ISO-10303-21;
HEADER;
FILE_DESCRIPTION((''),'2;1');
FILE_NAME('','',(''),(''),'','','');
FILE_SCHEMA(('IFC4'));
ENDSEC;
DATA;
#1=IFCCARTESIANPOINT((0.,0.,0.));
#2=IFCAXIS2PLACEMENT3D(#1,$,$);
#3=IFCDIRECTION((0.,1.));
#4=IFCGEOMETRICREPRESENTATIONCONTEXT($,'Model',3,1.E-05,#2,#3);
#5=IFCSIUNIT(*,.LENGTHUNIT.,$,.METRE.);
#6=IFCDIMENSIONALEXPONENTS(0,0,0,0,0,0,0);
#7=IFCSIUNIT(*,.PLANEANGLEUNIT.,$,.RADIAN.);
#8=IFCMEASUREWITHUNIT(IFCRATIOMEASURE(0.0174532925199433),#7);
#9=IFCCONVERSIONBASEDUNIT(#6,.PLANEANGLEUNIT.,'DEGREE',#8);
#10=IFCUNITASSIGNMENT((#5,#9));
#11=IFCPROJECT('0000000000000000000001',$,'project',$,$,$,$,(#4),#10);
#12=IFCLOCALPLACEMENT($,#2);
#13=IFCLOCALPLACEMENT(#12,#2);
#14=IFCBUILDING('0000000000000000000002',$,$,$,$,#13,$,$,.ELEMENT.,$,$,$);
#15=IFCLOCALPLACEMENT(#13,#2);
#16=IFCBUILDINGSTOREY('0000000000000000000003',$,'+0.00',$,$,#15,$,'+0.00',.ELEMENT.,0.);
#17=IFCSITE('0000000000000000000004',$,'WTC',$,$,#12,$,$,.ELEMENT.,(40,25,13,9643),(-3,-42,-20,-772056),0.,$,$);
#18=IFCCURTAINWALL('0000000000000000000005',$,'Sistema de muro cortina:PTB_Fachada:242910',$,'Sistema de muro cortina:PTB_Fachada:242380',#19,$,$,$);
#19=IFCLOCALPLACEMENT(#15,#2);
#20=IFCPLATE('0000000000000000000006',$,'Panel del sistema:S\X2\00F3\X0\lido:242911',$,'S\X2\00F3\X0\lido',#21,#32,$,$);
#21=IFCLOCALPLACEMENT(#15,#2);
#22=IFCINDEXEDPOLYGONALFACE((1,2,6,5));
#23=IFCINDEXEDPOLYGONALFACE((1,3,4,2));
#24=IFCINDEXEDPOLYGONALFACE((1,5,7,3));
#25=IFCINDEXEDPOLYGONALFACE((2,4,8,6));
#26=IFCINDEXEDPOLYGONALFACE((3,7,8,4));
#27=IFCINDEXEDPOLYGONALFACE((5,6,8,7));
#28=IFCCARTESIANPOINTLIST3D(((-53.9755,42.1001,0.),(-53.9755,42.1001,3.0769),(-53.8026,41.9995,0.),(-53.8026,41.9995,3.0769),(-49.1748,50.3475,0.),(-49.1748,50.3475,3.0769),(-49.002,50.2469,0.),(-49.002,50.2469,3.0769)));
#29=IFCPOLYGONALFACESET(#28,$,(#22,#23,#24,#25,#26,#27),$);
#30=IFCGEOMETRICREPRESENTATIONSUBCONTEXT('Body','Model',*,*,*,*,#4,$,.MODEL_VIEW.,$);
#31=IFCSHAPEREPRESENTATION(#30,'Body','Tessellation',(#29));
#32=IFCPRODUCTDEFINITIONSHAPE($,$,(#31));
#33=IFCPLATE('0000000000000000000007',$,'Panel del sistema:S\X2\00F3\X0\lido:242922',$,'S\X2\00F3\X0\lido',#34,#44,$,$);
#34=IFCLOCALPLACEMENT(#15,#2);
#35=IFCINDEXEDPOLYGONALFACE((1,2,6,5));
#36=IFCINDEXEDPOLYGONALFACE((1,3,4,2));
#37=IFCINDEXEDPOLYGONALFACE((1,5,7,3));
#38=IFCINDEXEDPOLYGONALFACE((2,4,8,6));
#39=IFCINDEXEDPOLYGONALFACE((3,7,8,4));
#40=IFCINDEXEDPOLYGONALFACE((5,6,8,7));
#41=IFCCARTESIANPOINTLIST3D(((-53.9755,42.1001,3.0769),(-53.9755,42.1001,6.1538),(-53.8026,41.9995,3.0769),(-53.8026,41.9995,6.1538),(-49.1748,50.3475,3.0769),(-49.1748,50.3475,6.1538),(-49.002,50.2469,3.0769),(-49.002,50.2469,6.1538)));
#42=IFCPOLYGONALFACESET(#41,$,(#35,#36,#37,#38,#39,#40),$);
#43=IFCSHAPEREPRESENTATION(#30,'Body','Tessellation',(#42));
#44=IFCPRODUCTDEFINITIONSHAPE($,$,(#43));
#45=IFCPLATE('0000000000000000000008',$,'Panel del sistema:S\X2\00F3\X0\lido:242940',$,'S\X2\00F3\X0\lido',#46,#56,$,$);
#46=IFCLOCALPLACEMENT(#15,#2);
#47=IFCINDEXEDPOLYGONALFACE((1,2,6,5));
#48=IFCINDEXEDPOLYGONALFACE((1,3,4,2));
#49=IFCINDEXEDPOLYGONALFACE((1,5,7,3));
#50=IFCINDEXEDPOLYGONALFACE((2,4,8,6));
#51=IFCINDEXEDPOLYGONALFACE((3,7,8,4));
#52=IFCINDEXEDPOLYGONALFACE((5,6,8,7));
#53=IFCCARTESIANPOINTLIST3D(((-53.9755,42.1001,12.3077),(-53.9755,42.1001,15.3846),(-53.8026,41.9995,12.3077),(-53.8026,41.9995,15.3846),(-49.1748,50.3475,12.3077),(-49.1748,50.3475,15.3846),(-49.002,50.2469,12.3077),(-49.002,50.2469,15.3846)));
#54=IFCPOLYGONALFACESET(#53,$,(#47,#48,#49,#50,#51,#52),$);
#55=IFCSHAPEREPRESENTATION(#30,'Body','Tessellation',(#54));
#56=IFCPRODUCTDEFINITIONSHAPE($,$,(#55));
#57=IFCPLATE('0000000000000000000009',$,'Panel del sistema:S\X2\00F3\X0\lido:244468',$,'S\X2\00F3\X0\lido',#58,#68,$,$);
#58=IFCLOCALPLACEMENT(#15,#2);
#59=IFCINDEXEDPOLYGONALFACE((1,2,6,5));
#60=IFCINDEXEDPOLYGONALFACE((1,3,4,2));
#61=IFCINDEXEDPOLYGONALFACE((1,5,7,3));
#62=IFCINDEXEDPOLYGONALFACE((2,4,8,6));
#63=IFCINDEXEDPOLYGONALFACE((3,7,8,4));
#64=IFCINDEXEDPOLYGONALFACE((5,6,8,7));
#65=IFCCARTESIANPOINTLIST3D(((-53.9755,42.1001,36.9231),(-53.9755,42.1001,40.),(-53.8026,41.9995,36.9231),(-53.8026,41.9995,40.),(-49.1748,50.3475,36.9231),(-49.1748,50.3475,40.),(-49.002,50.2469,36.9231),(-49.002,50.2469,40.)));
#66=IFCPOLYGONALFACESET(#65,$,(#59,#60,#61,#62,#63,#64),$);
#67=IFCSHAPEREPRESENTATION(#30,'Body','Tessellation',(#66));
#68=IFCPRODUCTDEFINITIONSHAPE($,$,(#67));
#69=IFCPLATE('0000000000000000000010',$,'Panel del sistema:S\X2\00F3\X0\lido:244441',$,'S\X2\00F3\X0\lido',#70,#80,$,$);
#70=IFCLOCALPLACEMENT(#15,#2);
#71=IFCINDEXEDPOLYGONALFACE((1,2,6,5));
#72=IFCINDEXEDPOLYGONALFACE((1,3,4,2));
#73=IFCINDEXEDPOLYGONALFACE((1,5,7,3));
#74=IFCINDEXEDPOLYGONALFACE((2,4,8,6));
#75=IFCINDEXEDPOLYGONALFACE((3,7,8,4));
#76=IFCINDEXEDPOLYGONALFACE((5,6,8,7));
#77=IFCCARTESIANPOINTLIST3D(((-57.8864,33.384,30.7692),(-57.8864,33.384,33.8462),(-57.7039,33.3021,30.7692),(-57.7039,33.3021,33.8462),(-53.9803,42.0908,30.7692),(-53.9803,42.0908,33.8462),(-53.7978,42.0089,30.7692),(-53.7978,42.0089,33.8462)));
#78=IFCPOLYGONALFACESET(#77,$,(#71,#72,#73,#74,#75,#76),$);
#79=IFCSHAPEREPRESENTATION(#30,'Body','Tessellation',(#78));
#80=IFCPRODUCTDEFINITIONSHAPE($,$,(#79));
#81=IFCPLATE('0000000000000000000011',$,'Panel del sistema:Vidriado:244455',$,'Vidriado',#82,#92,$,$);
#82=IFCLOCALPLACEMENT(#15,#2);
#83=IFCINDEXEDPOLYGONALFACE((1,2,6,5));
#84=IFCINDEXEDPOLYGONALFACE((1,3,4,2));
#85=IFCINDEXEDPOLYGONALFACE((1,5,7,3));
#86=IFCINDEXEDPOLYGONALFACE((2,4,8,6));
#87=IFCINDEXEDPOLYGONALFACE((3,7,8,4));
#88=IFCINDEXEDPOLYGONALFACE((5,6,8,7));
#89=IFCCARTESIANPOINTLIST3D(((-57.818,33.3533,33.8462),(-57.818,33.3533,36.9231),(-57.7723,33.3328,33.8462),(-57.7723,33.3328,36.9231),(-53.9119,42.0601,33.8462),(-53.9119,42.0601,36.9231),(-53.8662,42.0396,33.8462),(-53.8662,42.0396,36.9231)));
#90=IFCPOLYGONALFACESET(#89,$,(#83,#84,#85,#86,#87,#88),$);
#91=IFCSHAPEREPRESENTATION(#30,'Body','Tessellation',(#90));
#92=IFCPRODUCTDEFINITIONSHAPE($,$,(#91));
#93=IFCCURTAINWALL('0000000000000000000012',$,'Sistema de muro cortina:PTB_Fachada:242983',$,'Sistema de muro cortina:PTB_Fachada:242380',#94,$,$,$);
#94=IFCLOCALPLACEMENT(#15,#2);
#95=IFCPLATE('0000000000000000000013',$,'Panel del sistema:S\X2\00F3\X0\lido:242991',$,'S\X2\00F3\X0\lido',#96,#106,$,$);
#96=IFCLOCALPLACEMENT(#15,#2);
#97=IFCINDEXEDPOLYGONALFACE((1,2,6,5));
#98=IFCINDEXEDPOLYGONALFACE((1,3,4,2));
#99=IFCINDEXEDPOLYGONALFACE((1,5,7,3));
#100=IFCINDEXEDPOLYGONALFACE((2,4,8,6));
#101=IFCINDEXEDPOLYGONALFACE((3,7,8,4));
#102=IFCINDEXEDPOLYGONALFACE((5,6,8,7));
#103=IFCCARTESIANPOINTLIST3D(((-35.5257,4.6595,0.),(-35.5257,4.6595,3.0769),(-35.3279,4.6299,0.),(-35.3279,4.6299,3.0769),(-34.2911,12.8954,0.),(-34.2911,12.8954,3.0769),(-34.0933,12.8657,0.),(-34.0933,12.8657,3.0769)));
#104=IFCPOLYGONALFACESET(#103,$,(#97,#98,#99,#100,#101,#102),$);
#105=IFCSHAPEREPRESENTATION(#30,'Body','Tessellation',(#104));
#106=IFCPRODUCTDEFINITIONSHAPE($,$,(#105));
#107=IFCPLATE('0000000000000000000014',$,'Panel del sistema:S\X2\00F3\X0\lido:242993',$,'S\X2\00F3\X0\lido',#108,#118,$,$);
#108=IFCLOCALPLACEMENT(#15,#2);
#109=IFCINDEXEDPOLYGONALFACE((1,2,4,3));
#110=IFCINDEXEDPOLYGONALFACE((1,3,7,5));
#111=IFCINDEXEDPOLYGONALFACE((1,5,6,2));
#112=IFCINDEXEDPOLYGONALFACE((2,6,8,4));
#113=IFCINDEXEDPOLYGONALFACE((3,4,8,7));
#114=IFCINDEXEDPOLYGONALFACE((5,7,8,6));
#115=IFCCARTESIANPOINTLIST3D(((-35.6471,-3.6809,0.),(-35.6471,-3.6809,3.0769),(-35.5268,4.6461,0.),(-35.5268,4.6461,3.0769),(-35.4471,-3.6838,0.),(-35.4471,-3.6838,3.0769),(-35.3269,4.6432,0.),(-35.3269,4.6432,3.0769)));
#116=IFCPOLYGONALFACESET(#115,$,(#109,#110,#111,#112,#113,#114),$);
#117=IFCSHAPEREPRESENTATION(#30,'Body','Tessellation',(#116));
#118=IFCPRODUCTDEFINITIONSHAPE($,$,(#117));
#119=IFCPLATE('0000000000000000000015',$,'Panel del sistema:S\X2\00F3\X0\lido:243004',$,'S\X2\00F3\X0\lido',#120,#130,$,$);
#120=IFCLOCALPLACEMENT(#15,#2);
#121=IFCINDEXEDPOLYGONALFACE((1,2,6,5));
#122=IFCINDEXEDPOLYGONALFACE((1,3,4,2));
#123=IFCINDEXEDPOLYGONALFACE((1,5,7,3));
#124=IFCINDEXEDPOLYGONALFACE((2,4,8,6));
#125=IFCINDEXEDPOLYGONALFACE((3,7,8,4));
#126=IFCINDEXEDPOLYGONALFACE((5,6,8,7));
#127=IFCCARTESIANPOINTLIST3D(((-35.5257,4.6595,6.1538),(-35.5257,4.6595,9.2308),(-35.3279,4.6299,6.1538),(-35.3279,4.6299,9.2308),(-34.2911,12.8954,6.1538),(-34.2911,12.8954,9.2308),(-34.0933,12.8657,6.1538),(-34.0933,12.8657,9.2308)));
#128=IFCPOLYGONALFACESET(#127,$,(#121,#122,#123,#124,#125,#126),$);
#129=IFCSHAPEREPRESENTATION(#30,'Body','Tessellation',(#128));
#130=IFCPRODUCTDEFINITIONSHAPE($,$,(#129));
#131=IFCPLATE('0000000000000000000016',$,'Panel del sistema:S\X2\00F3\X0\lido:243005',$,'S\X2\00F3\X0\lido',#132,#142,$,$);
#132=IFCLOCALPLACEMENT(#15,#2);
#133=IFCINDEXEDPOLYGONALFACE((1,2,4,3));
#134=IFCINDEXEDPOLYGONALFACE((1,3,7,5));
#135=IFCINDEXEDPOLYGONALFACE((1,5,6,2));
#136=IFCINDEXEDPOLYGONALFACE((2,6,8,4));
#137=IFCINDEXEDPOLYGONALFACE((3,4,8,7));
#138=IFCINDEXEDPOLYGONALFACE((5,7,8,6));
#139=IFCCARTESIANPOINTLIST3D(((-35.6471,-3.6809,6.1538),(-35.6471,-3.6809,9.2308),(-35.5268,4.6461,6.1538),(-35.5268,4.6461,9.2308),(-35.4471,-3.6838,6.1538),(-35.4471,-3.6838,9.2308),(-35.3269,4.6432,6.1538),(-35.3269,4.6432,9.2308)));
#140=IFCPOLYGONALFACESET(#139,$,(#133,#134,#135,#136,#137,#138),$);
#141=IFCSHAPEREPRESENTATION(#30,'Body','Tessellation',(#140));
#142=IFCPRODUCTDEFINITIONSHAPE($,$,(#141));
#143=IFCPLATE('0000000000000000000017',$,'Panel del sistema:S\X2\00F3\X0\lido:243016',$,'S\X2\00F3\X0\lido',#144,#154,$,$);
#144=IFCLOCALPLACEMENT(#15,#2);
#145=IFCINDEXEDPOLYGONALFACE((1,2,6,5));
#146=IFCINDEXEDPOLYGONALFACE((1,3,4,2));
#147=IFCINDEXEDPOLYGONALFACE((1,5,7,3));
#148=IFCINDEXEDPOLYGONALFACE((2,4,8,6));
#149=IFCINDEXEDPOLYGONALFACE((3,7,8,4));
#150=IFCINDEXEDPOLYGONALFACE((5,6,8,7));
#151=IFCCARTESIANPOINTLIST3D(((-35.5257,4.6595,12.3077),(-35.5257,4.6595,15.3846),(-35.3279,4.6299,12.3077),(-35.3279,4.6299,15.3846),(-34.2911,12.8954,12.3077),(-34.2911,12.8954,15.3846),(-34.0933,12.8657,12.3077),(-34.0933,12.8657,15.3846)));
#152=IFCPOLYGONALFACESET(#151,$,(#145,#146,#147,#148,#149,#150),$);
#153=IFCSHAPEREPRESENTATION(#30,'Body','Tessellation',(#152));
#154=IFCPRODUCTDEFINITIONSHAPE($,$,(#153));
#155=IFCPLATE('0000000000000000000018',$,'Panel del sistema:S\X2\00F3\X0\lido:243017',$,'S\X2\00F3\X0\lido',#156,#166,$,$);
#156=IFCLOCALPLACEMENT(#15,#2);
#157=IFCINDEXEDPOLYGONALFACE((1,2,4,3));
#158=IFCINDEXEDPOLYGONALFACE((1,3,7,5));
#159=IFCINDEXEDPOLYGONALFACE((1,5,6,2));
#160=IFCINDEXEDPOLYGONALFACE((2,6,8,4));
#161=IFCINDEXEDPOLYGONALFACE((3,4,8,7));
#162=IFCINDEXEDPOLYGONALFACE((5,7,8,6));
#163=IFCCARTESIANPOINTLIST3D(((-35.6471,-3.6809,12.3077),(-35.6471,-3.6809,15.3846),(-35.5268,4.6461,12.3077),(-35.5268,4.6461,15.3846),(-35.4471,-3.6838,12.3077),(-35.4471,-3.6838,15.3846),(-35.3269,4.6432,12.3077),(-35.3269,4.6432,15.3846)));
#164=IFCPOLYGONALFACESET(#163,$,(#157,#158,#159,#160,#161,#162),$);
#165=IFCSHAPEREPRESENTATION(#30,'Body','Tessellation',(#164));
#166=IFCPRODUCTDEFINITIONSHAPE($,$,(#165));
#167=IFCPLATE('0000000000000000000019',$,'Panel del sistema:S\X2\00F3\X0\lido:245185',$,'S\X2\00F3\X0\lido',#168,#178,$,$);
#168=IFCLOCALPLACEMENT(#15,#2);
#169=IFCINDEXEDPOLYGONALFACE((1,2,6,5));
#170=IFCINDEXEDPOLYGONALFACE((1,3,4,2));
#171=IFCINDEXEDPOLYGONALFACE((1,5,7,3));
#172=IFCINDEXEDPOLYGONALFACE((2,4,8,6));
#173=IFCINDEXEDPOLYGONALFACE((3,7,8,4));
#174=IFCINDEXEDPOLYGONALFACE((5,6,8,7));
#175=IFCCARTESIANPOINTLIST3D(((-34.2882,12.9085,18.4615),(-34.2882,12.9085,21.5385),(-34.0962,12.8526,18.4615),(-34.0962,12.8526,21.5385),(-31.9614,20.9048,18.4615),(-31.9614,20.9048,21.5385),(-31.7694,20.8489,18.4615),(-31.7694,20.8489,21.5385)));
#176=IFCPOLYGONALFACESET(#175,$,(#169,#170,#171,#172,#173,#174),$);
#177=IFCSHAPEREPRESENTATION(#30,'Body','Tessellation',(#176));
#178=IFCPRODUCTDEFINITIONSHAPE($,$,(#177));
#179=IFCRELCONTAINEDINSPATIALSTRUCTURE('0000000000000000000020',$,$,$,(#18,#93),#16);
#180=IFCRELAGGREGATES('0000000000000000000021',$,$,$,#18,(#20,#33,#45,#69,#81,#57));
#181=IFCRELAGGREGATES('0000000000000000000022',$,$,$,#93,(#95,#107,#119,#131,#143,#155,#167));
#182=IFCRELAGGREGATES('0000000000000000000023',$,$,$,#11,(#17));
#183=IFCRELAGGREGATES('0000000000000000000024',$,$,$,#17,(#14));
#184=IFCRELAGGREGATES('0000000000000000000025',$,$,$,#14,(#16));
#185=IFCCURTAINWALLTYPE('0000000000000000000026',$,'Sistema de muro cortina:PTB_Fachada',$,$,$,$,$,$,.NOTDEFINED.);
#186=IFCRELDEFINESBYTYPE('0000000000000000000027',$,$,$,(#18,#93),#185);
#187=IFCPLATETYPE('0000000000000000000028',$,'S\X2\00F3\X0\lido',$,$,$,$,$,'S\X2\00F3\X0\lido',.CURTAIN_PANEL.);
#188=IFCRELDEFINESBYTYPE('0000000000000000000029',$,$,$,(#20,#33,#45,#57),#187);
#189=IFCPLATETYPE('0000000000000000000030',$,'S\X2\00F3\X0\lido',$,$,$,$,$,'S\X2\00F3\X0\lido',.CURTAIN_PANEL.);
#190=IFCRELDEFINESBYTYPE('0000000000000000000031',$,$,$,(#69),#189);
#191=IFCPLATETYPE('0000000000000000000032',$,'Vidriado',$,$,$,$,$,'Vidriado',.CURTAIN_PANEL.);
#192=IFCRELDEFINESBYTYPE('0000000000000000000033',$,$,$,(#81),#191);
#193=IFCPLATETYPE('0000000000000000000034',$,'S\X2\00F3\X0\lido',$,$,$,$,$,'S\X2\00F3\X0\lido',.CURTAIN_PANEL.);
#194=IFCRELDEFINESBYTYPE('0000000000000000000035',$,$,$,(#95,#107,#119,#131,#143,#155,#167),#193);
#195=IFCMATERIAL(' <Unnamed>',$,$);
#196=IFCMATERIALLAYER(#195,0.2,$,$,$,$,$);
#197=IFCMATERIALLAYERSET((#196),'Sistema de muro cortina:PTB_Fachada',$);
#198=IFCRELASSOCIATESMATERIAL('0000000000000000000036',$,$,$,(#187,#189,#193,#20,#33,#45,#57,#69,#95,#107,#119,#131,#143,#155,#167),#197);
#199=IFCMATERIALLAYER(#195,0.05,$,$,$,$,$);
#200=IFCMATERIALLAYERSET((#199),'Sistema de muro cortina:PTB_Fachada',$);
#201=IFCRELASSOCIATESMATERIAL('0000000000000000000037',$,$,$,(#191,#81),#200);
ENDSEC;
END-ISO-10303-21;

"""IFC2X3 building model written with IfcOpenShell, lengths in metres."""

from ifc_helpers import new_model, entity, si_unit, converted_unit, direction, frame, frame_2d, origin, origin_2d_with_axis, place, context, subcontext, project, spatial, rectangle, extrude, source, transform, mapped, material, layer, layer_set, layer_usage, type_object, type_shapes, element, aggregate, save


model = new_model("IFC2X3")

# Units and contexts
model_context = context("Model", 3, precision=1e-05, world=origin(), true_north=direction((0.0, 1.0)))
body_context = subcontext(model_context, "Body", "Model", "MODEL_VIEW")
ifc_project = project(units=[si_unit("LENGTHUNIT", "METRE"), converted_unit("PLANEANGLEUNIT", "DEGREE", entity("IfcRatioMeasure", 0.0174532925199433), si_unit("PLANEANGLEUNIT", "RADIAN"), dimensions=[0, 0, 0, 0, 0, 0, 0])], contexts=[model_context])

# Site, building, storey
site_placement = place(None, origin())
site = spatial("IfcSite", under=ifc_project, at=site_placement, Name="WTC", CompositionType="ELEMENT", RefLatitude=(40, 25, 13, 9643), RefLongitude=(-3, -42, -20, -772056), RefElevation=0.0)
building_placement = place(site_placement, origin())
building = spatial("IfcBuilding", under=site, at=building_placement, CompositionType="ELEMENT")
storey_placement = place(building_placement, origin())
storey = spatial("IfcBuildingStorey", under=building, at=storey_placement, Name="+0.00", LongName="+0.00", CompositionType="ELEMENT", Elevation=0.0)

# Curtain walls, plates
curtain_wall_type = type_object("IfcCurtainWallType", Name="Sistema de muro cortina:PTB_Fachada", PredefinedType="NOTDEFINED")
curtain_wall_1_placement = place(storey_placement, origin())
curtain_wall_1 = element("IfcCurtainWall", 1, at=curtain_wall_1_placement, inside=storey, type_object=curtain_wall_type, Name="Sistema de muro cortina:PTB_Fachada:242910", ObjectType="Sistema de muro cortina:PTB_Fachada:242380")
ifc_material_1 = material(Name=" <Unnamed>")
ifc_layer_1 = layer(ifc_material_1, 0.2)
ifc_layer_set_1 = layer_set([ifc_layer_1], Name="Sistema de muro cortina:PTB_Fachada")
ifc_layer_usage_1 = layer_usage(ifc_layer_set_1, "AXIS3", "POSITIVE", 0.0)
plate_type_1 = type_object("IfcPlateType", Name="Sólido", ElementType="Sólido", PredefinedType="CURTAIN_PANEL", material=ifc_layer_set_1)
shared_shape_1 = source(origin(), body_context, "Body", "SweptSolid", [
    extrude(rectangle(XDim=0.2, YDim=9.5428, at=frame_2d((0.0, 0.0), x_axis=(1.0, 0.0))), frame((0.0, 0.0, 0.0), z_axis=(0.0, 0.0, 1.0), x_axis=(0.0, 1.0, 0.0)), (0.0, 0.0, 1.0), 3.0769),
])
type_shapes(plate_type_1, [shared_shape_1])
plate_1_placement = place(curtain_wall_1_placement, frame((-51.4887, 46.1735, 0.0), z_axis=(0.0, 0.0, 1.0), x_axis=(-0.503062, -0.864251, 0.0)))
plate_1 = element("IfcPlate", 2, at=plate_1_placement, type_object=plate_type_1, material=ifc_layer_usage_1, Name="Panel del sistema:Sólido:242911", ObjectType="Sólido", context=body_context, shape_type="MappedRepresentation", body=[
    mapped(shared_shape_1, transform((0.0, 0.0, 0.0), scale=1.0)),
])
ifc_layer_usage_2 = layer_usage(ifc_layer_set_1, "AXIS3", "POSITIVE", 0.0)
plate_2_placement = place(curtain_wall_1_placement, frame((-51.4887, 46.1735, 3.0769), z_axis=(0.0, 0.0, 1.0), x_axis=(-0.503062, -0.864251, 0.0)))
plate_2 = element("IfcPlate", 3, at=plate_2_placement, type_object=plate_type_1, material=ifc_layer_usage_2, Name="Panel del sistema:Sólido:242922", ObjectType="Sólido", context=body_context, shape_type="MappedRepresentation", body=[
    mapped(shared_shape_1, transform((0.0, 0.0, 0.0), scale=1.0)),
])
ifc_layer_usage_3 = layer_usage(ifc_layer_set_1, "AXIS3", "POSITIVE", 0.0)
plate_3_placement = place(curtain_wall_1_placement, frame((-51.4887, 46.1735, 12.3077), z_axis=(0.0, 0.0, 1.0), x_axis=(-0.503062, -0.864251, 0.0)))
plate_3 = element("IfcPlate", 4, at=plate_3_placement, type_object=plate_type_1, material=ifc_layer_usage_3, Name="Panel del sistema:Sólido:242940", ObjectType="Sólido", context=body_context, shape_type="MappedRepresentation", body=[
    mapped(shared_shape_1, transform((0.0, 0.0, 0.0), scale=1.0)),
])
ifc_layer_usage_4 = layer_usage(ifc_layer_set_1, "AXIS3", "POSITIVE", 0.0)
plate_4_placement = place(curtain_wall_1_placement, frame((-51.4887, 46.1735, 36.9231), z_axis=(0.0, 0.0, 1.0), x_axis=(-0.503062, -0.864251, 0.0)))
plate_4 = element("IfcPlate", 5, at=plate_4_placement, type_object=plate_type_1, material=ifc_layer_usage_4, Name="Panel del sistema:Sólido:244468", ObjectType="Sólido", context=body_context, shape_type="MappedRepresentation", body=[
    mapped(shared_shape_1, transform((0.0, 0.0, 0.0), scale=1.0)),
])
ifc_layer_usage_5 = layer_usage(ifc_layer_set_1, "AXIS3", "POSITIVE", 0.0)
plate_type_2 = type_object("IfcPlateType", Name="Sólido", ElementType="Sólido", PredefinedType="CURTAIN_PANEL", material=ifc_layer_set_1)
shared_shape_2 = source(origin(), body_context, "Body", "SweptSolid", [
    extrude(rectangle(XDim=0.2, YDim=9.5428, at=frame_2d((0.0, 0.0), x_axis=(1.0, 0.0))), frame((0.0, 0.0, 0.0), z_axis=(0.0, 0.0, 1.0), x_axis=(0.0, 1.0, 0.0)), (0.0, 0.0, 1.0), 3.0769),
])
type_shapes(plate_type_2, [shared_shape_2])
plate_5_placement = place(curtain_wall_1_placement, frame((-55.8421, 37.6964, 30.7692), z_axis=(0.0, 0.0, 1.0), x_axis=(-0.409321, -0.91239, 0.0)))
plate_5 = element("IfcPlate", 6, at=plate_5_placement, type_object=plate_type_2, material=ifc_layer_usage_5, Name="Panel del sistema:Sólido:244441", ObjectType="Sólido", context=body_context, shape_type="MappedRepresentation", body=[
    mapped(shared_shape_2, transform((0.0, 0.0, 0.0), scale=1.0)),
])
ifc_layer_2 = layer(ifc_material_1, 0.05)
ifc_layer_set_2 = layer_set([ifc_layer_2], Name="Sistema de muro cortina:PTB_Fachada")
ifc_layer_usage_6 = layer_usage(ifc_layer_set_2, "AXIS3", "POSITIVE", 0.0)
plate_type_3 = type_object("IfcPlateType", Name="Vidriado", ElementType="Vidriado", PredefinedType="CURTAIN_PANEL", material=ifc_layer_set_2)
shared_shape_3 = source(origin(), body_context, "Body", "SweptSolid", [
    extrude(rectangle(XDim=0.05, YDim=9.5428, at=origin_2d_with_axis()), frame((0.0, 0.0, 0.0), z_axis=(0.0, 0.0, 1.0), x_axis=(0.0, 1.0, 0.0)), (0.0, 0.0, 1.0), 3.0769),
])
type_shapes(plate_type_3, [shared_shape_3])
plate_6_placement = place(curtain_wall_1_placement, frame((-55.8421, 37.6964, 33.8462), z_axis=(0.0, 0.0, 1.0), x_axis=(-0.409321, -0.91239, 0.0)))
plate_6 = element("IfcPlate", 7, at=plate_6_placement, type_object=plate_type_3, material=ifc_layer_usage_6, Name="Panel del sistema:Vidriado:244455", ObjectType="Vidriado", context=body_context, shape_type="MappedRepresentation", body=[
    mapped(shared_shape_3, transform((0.0, 0.0, 0.0), scale=1.0)),
])
aggregate(curtain_wall_1, [plate_1, plate_2, plate_3, plate_5, plate_6, plate_4])
curtain_wall_2_placement = place(storey_placement, origin())
curtain_wall_2 = element("IfcCurtainWall", 8, at=curtain_wall_2_placement, inside=storey, type_object=curtain_wall_type, Name="Sistema de muro cortina:PTB_Fachada:242983", ObjectType="Sistema de muro cortina:PTB_Fachada:242380")
ifc_layer_usage_7 = layer_usage(ifc_layer_set_1, "AXIS3", "POSITIVE", 0.0)
plate_type_4 = type_object("IfcPlateType", Name="Sólido", ElementType="Sólido", PredefinedType="CURTAIN_PANEL", material=ifc_layer_set_1)
shared_shape_4 = source(origin(), body_context, "Body", "SweptSolid", [
    extrude(rectangle(XDim=0.2, YDim=8.3279, at=origin_2d_with_axis()), frame((0.0, 0.0, 0.0), z_axis=(0.0, 0.0, 1.0), x_axis=(0.0, 1.0, 0.0)), (0.0, 0.0, 1.0), 3.0769),
])
type_shapes(plate_type_4, [shared_shape_4])
plate_7_placement = place(curtain_wall_2_placement, frame((-34.8095, 8.7626, 3.0769), z_axis=(0.0, 0.0, -1.0), x_axis=(-0.148255, -0.988949, 0.0)))
plate_7 = element("IfcPlate", 9, at=plate_7_placement, type_object=plate_type_4, material=ifc_layer_usage_7, Name="Panel del sistema:Sólido:242991", ObjectType="Sólido", context=body_context, shape_type="MappedRepresentation", body=[
    mapped(shared_shape_4, transform((0.0, 0.0, 0.0), scale=1.0)),
])
ifc_layer_usage_8 = layer_usage(ifc_layer_set_1, "AXIS3", "POSITIVE", 0.0)
plate_8_placement = place(curtain_wall_2_placement, frame((-35.487, 0.4812, 3.0769), z_axis=(0.0, 0.0, -1.0), x_axis=(-0.014441, -0.999896, 0.0)))
plate_8 = element("IfcPlate", 10, at=plate_8_placement, type_object=plate_type_4, material=ifc_layer_usage_8, Name="Panel del sistema:Sólido:242993", ObjectType="Sólido", context=body_context, shape_type="MappedRepresentation", body=[
    mapped(shared_shape_4, transform((0.0, 0.0, 0.0), scale=1.0)),
])
ifc_layer_usage_9 = layer_usage(ifc_layer_set_1, "AXIS3", "POSITIVE", 0.0)
plate_9_placement = place(curtain_wall_2_placement, frame((-34.8095, 8.7626, 9.2308), z_axis=(0.0, 0.0, -1.0), x_axis=(-0.148255, -0.988949, 0.0)))
plate_9 = element("IfcPlate", 11, at=plate_9_placement, type_object=plate_type_4, material=ifc_layer_usage_9, Name="Panel del sistema:Sólido:243004", ObjectType="Sólido", context=body_context, shape_type="MappedRepresentation", body=[
    mapped(shared_shape_4, transform((0.0, 0.0, 0.0), scale=1.0)),
])
ifc_layer_usage_10 = layer_usage(ifc_layer_set_1, "AXIS3", "POSITIVE", 0.0)
plate_10_placement = place(curtain_wall_2_placement, frame((-35.487, 0.4812, 9.2308), z_axis=(0.0, 0.0, -1.0), x_axis=(-0.014441, -0.999896, 0.0)))
plate_10 = element("IfcPlate", 12, at=plate_10_placement, type_object=plate_type_4, material=ifc_layer_usage_10, Name="Panel del sistema:Sólido:243005", ObjectType="Sólido", context=body_context, shape_type="MappedRepresentation", body=[
    mapped(shared_shape_4, transform((0.0, 0.0, 0.0), scale=1.0)),
])
ifc_layer_usage_11 = layer_usage(ifc_layer_set_1, "AXIS3", "POSITIVE", 0.0)
plate_11_placement = place(curtain_wall_2_placement, frame((-34.8095, 8.7626, 15.3846), z_axis=(0.0, 0.0, -1.0), x_axis=(-0.148255, -0.988949, 0.0)))
plate_11 = element("IfcPlate", 13, at=plate_11_placement, type_object=plate_type_4, material=ifc_layer_usage_11, Name="Panel del sistema:Sólido:243016", ObjectType="Sólido", context=body_context, shape_type="MappedRepresentation", body=[
    mapped(shared_shape_4, transform((0.0, 0.0, 0.0), scale=1.0)),
])
ifc_layer_usage_12 = layer_usage(ifc_layer_set_1, "AXIS3", "POSITIVE", 0.0)
plate_12_placement = place(curtain_wall_2_placement, frame((-35.487, 0.4812, 15.3846), z_axis=(0.0, 0.0, -1.0), x_axis=(-0.014441, -0.999896, 0.0)))
plate_12 = element("IfcPlate", 14, at=plate_12_placement, type_object=plate_type_4, material=ifc_layer_usage_12, Name="Panel del sistema:Sólido:243017", ObjectType="Sólido", context=body_context, shape_type="MappedRepresentation", body=[
    mapped(shared_shape_4, transform((0.0, 0.0, 0.0), scale=1.0)),
])
ifc_layer_usage_13 = layer_usage(ifc_layer_set_1, "AXIS3", "POSITIVE", 0.0)
plate_13_placement = place(curtain_wall_2_placement, frame((-33.0288, 16.8787, 21.5385), z_axis=(0.0, 0.0, -1.0), x_axis=(-0.279396, -0.960176, 0.0)))
plate_13 = element("IfcPlate", 15, at=plate_13_placement, type_object=plate_type_4, material=ifc_layer_usage_13, Name="Panel del sistema:Sólido:245185", ObjectType="Sólido", context=body_context, shape_type="MappedRepresentation", body=[
    mapped(shared_shape_4, transform((0.0, 0.0, 0.0), scale=1.0)),
])
aggregate(curtain_wall_2, [plate_7, plate_8, plate_9, plate_10, plate_11, plate_12, plate_13])

save(model, "model.ifc")
